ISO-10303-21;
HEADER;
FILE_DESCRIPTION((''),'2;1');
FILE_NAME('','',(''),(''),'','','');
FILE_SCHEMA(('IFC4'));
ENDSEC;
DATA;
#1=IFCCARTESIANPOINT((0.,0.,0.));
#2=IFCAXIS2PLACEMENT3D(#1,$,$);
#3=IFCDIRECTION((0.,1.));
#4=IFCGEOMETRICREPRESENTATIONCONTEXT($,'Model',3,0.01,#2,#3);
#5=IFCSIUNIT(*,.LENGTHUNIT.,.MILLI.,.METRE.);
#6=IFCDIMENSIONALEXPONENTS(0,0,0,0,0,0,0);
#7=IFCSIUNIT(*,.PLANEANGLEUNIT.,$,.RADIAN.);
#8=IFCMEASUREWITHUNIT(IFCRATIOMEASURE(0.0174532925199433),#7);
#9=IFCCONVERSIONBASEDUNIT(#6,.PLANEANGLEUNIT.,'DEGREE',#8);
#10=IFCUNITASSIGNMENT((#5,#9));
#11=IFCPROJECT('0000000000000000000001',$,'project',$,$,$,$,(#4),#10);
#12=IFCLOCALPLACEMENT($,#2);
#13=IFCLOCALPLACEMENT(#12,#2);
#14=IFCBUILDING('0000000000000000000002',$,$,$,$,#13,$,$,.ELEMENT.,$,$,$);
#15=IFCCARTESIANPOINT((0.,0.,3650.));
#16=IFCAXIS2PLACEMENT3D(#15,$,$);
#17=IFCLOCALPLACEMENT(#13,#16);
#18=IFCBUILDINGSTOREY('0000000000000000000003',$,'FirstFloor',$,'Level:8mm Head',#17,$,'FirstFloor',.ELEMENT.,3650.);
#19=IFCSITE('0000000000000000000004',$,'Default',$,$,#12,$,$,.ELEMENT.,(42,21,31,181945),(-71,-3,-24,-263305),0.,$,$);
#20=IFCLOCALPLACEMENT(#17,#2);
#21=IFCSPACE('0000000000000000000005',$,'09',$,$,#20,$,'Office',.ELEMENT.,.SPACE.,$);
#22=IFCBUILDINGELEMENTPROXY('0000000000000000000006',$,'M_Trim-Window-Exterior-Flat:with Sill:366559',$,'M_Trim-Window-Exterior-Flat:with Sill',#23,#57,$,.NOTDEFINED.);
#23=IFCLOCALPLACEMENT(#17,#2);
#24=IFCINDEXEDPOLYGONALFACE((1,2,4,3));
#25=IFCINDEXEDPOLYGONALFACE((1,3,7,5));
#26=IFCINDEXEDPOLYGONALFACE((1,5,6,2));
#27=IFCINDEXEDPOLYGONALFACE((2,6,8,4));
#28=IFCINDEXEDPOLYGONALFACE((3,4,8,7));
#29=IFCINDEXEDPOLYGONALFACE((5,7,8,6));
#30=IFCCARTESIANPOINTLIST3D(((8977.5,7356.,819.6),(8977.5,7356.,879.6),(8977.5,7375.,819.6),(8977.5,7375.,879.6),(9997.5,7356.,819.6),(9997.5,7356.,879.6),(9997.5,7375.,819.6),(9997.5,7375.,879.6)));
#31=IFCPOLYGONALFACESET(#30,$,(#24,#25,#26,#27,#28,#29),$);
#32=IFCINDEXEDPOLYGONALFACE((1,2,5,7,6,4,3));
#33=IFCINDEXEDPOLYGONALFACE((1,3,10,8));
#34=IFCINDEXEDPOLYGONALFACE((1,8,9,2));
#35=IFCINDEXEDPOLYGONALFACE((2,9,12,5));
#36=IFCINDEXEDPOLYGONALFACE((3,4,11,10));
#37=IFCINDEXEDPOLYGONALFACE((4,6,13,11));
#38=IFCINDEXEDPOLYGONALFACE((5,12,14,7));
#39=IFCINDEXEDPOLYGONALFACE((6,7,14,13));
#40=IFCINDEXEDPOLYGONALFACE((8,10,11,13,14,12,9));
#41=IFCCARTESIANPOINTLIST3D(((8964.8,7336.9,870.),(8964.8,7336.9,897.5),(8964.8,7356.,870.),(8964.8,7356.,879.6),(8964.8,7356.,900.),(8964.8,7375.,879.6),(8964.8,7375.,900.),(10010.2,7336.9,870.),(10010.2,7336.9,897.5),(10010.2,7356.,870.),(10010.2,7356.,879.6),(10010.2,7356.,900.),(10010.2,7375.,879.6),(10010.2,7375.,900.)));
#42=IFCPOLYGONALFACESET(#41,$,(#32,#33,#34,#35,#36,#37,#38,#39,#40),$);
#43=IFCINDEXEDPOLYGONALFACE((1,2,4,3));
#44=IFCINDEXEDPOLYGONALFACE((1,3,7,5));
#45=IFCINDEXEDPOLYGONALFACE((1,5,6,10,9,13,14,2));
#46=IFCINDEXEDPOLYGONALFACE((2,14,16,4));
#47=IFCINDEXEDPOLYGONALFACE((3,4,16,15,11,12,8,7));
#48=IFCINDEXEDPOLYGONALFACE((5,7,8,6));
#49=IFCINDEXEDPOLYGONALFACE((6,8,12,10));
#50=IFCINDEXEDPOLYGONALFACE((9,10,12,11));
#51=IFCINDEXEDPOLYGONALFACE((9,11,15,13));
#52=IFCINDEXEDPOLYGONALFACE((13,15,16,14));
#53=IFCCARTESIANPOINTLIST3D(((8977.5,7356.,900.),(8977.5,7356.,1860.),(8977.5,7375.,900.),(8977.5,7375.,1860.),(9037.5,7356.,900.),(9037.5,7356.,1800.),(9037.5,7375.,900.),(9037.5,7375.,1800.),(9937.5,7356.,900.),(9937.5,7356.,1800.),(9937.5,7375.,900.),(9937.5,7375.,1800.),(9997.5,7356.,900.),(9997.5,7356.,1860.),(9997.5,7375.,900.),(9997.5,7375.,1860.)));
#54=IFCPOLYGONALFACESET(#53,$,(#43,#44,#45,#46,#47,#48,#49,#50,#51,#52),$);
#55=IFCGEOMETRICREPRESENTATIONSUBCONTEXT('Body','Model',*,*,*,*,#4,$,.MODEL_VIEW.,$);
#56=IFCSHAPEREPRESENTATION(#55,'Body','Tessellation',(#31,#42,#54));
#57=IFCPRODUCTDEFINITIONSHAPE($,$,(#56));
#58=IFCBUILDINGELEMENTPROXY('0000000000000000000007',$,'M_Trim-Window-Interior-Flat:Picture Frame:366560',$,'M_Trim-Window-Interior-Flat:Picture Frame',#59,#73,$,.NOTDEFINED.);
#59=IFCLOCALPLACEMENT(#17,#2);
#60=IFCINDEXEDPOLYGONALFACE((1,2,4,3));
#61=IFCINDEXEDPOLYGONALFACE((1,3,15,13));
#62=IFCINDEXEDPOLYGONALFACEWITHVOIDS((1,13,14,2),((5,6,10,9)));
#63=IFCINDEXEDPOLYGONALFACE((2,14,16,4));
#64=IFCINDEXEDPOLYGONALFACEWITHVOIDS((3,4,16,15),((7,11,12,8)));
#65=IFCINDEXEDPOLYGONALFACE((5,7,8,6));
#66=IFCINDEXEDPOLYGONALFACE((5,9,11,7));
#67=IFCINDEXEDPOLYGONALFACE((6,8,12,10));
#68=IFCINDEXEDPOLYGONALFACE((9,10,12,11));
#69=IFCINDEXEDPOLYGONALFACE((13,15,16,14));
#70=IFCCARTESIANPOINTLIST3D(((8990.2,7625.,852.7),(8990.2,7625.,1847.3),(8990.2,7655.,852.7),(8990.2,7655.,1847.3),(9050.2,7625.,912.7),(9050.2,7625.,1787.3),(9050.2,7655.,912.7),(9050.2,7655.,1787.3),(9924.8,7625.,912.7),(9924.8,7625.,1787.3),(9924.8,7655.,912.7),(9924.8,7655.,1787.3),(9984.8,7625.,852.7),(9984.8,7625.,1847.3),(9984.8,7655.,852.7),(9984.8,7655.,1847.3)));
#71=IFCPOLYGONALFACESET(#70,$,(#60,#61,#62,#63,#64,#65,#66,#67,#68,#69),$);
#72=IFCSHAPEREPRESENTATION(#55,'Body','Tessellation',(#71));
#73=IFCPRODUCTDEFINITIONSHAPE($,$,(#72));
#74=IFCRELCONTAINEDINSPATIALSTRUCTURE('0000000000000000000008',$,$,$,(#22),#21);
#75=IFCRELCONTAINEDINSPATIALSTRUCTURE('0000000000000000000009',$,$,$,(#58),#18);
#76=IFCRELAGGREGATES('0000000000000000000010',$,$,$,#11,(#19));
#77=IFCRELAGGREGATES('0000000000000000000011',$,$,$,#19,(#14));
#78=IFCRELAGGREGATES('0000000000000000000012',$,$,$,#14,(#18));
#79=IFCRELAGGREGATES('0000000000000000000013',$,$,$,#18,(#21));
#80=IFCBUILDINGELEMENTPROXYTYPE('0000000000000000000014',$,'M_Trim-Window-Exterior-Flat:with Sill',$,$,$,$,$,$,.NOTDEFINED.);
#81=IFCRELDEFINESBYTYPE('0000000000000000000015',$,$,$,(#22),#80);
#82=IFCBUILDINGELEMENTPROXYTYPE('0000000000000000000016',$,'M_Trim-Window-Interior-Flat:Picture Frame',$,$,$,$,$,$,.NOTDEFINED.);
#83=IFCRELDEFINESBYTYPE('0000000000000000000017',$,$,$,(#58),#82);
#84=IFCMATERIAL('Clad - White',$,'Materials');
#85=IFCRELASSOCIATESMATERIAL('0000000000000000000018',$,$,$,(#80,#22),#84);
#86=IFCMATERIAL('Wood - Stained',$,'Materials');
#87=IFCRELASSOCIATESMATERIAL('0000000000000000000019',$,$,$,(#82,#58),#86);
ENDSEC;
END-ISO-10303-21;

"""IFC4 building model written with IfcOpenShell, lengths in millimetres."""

from ifc_helpers import new_model, entity, si_unit, converted_unit, direction, frame, frame_2d, origin, place, context, subcontext, project, spatial, polyline, rectangle, outline, extrude, source, transform, mapped, material, type_object, type_shapes, element, save


model = new_model("IFC4")

# Units and contexts
model_context = context("Model", 3, precision=0.01, world=origin(), true_north=direction((0.0, 1.0)))
body_context = subcontext(model_context, "Body", "Model", "MODEL_VIEW")
ifc_project = project(units=[si_unit("LENGTHUNIT", "METRE", prefix="MILLI"), converted_unit("PLANEANGLEUNIT", "DEGREE", entity("IfcRatioMeasure", 0.0174532925199433), si_unit("PLANEANGLEUNIT", "RADIAN"), dimensions=[0, 0, 0, 0, 0, 0, 0])], contexts=[model_context])

# Site, building, storey
site_placement = place(None, origin())
site = spatial("IfcSite", under=ifc_project, at=site_placement, Name="Default", CompositionType="ELEMENT", RefLatitude=(42, 21, 31, 181945), RefLongitude=(-71, -3, -24, -263305), RefElevation=0.0)
building_placement = place(site_placement, origin())
building = spatial("IfcBuilding", under=site, at=building_placement, CompositionType="ELEMENT")
storey_placement = place(building_placement, frame((0.0, 0.0, 3650.0)))
storey = spatial("IfcBuildingStorey", under=building, at=storey_placement, Name="FirstFloor", ObjectType="Level:8mm Head", LongName="FirstFloor", CompositionType="ELEMENT", Elevation=3650.0)

# Shared definitions
ifc_material_1 = material(Name="Clad - White", Category="Materials")
ifc_material_2 = material(Name="Wood - Stained", Category="Materials")

# Shared definitions
space_1_placement = place(storey_placement, origin())
space_1 = spatial("IfcSpace", under=storey, at=space_1_placement, Name="09", LongName="Office", CompositionType="ELEMENT", PredefinedType="SPACE")

# Building element proxies
building_element_proxy_type_1 = type_object("IfcBuildingElementProxyType", Name="M_Trim-Window-Exterior-Flat:with Sill", PredefinedType="NOTDEFINED", material=ifc_material_1)
shared_shape_1 = source(origin(), body_context, "Body", "SweptSolid", [
    extrude(rectangle(XDim=1020.0, YDim=60.0, at=frame_2d((0.0, 0.0), x_axis=(1.0, 0.0))), frame((0.0, -950.4, 0.0), z_axis=(0.0, 0.0, 1.0), x_axis=(-1.0, 0.0, 0.0)), (0.0, 0.0, 1.0), 19.1),
    extrude(outline(polyline([(-19.0, -15.2), (0.0, -15.2), (0.0, -5.7), (19.0, -5.7), (19.0, 14.8), (0.0, 14.8), (-19.0, 12.3), (-19.0, -15.2)])), frame((-522.7, -914.8, 19.0), z_axis=(1.0, 0.0, 0.0), x_axis=(0.0, 0.0, -1.0)), (0.0, 0.0, 1.0), 1045.4),
    extrude(outline(polyline([(-495.0, -510.0), (465.0, -510.0), (465.0, -450.0), (-435.0, -450.0), (-435.0, 450.0), (465.0, 450.0), (465.0, 510.0), (-495.0, 510.0), (-495.0, -510.0)])), frame((0.0, -435.0, 0.0), z_axis=(0.0, 0.0, 1.0), x_axis=(0.0, -1.0, 0.0)), (0.0, 0.0, 1.0), 19.1),
])
type_shapes(building_element_proxy_type_1, [shared_shape_1])
proxy_1_placement = place(space_1_placement, frame((9487.5, 7375.0, 1800.0), z_axis=(0.0, -1.0, 0.0), x_axis=(1.0, 0.0, 0.0)))
element("IfcBuildingElementProxy", 1, at=proxy_1_placement, inside=space_1, type_object=building_element_proxy_type_1, material=ifc_material_1, Name="M_Trim-Window-Exterior-Flat:with Sill:366559", ObjectType="M_Trim-Window-Exterior-Flat:with Sill", PredefinedType="NOTDEFINED", context=body_context, shape_type="MappedRepresentation", body=[
    mapped(shared_shape_1, transform((0.0, 0.0, 0.0), scale=1.0)),
])
building_element_proxy_type_2 = type_object("IfcBuildingElementProxyType", Name="M_Trim-Window-Interior-Flat:Picture Frame", PredefinedType="NOTDEFINED", material=ifc_material_2)
shared_shape_2 = source(origin(), body_context, "Body", "SweptSolid", [
    extrude(outline(polyline([(-497.3, -497.3), (497.3, -497.3), (497.3, 497.3), (-497.3, 497.3), (-497.3, -497.3)]), holes=[polyline([(-437.3, -437.3), (-437.3, 437.3), (437.3, 437.3), (437.3, -437.3), (-437.3, -437.3)])]), frame((0.0, -450.0, 0.0), z_axis=(0.0, 0.0, 1.0), x_axis=(-1.0, 0.0, 0.0)), (0.0, 0.0, 1.0), 30.0),
])
type_shapes(building_element_proxy_type_2, [shared_shape_2])
proxy_2_placement = place(storey_placement, frame((9487.5, 7625.0, 1800.0), z_axis=(0.0, 1.0, 0.0), x_axis=(-1.0, 0.0, 0.0)))
element("IfcBuildingElementProxy", 2, at=proxy_2_placement, inside=storey, type_object=building_element_proxy_type_2, material=ifc_material_2, Name="M_Trim-Window-Interior-Flat:Picture Frame:366560", ObjectType="M_Trim-Window-Interior-Flat:Picture Frame", PredefinedType="NOTDEFINED", context=body_context, shape_type="MappedRepresentation", body=[
    mapped(shared_shape_2, transform((0.0, 0.0, 0.0), scale=1.0)),
])

save(model, "model.ifc")
